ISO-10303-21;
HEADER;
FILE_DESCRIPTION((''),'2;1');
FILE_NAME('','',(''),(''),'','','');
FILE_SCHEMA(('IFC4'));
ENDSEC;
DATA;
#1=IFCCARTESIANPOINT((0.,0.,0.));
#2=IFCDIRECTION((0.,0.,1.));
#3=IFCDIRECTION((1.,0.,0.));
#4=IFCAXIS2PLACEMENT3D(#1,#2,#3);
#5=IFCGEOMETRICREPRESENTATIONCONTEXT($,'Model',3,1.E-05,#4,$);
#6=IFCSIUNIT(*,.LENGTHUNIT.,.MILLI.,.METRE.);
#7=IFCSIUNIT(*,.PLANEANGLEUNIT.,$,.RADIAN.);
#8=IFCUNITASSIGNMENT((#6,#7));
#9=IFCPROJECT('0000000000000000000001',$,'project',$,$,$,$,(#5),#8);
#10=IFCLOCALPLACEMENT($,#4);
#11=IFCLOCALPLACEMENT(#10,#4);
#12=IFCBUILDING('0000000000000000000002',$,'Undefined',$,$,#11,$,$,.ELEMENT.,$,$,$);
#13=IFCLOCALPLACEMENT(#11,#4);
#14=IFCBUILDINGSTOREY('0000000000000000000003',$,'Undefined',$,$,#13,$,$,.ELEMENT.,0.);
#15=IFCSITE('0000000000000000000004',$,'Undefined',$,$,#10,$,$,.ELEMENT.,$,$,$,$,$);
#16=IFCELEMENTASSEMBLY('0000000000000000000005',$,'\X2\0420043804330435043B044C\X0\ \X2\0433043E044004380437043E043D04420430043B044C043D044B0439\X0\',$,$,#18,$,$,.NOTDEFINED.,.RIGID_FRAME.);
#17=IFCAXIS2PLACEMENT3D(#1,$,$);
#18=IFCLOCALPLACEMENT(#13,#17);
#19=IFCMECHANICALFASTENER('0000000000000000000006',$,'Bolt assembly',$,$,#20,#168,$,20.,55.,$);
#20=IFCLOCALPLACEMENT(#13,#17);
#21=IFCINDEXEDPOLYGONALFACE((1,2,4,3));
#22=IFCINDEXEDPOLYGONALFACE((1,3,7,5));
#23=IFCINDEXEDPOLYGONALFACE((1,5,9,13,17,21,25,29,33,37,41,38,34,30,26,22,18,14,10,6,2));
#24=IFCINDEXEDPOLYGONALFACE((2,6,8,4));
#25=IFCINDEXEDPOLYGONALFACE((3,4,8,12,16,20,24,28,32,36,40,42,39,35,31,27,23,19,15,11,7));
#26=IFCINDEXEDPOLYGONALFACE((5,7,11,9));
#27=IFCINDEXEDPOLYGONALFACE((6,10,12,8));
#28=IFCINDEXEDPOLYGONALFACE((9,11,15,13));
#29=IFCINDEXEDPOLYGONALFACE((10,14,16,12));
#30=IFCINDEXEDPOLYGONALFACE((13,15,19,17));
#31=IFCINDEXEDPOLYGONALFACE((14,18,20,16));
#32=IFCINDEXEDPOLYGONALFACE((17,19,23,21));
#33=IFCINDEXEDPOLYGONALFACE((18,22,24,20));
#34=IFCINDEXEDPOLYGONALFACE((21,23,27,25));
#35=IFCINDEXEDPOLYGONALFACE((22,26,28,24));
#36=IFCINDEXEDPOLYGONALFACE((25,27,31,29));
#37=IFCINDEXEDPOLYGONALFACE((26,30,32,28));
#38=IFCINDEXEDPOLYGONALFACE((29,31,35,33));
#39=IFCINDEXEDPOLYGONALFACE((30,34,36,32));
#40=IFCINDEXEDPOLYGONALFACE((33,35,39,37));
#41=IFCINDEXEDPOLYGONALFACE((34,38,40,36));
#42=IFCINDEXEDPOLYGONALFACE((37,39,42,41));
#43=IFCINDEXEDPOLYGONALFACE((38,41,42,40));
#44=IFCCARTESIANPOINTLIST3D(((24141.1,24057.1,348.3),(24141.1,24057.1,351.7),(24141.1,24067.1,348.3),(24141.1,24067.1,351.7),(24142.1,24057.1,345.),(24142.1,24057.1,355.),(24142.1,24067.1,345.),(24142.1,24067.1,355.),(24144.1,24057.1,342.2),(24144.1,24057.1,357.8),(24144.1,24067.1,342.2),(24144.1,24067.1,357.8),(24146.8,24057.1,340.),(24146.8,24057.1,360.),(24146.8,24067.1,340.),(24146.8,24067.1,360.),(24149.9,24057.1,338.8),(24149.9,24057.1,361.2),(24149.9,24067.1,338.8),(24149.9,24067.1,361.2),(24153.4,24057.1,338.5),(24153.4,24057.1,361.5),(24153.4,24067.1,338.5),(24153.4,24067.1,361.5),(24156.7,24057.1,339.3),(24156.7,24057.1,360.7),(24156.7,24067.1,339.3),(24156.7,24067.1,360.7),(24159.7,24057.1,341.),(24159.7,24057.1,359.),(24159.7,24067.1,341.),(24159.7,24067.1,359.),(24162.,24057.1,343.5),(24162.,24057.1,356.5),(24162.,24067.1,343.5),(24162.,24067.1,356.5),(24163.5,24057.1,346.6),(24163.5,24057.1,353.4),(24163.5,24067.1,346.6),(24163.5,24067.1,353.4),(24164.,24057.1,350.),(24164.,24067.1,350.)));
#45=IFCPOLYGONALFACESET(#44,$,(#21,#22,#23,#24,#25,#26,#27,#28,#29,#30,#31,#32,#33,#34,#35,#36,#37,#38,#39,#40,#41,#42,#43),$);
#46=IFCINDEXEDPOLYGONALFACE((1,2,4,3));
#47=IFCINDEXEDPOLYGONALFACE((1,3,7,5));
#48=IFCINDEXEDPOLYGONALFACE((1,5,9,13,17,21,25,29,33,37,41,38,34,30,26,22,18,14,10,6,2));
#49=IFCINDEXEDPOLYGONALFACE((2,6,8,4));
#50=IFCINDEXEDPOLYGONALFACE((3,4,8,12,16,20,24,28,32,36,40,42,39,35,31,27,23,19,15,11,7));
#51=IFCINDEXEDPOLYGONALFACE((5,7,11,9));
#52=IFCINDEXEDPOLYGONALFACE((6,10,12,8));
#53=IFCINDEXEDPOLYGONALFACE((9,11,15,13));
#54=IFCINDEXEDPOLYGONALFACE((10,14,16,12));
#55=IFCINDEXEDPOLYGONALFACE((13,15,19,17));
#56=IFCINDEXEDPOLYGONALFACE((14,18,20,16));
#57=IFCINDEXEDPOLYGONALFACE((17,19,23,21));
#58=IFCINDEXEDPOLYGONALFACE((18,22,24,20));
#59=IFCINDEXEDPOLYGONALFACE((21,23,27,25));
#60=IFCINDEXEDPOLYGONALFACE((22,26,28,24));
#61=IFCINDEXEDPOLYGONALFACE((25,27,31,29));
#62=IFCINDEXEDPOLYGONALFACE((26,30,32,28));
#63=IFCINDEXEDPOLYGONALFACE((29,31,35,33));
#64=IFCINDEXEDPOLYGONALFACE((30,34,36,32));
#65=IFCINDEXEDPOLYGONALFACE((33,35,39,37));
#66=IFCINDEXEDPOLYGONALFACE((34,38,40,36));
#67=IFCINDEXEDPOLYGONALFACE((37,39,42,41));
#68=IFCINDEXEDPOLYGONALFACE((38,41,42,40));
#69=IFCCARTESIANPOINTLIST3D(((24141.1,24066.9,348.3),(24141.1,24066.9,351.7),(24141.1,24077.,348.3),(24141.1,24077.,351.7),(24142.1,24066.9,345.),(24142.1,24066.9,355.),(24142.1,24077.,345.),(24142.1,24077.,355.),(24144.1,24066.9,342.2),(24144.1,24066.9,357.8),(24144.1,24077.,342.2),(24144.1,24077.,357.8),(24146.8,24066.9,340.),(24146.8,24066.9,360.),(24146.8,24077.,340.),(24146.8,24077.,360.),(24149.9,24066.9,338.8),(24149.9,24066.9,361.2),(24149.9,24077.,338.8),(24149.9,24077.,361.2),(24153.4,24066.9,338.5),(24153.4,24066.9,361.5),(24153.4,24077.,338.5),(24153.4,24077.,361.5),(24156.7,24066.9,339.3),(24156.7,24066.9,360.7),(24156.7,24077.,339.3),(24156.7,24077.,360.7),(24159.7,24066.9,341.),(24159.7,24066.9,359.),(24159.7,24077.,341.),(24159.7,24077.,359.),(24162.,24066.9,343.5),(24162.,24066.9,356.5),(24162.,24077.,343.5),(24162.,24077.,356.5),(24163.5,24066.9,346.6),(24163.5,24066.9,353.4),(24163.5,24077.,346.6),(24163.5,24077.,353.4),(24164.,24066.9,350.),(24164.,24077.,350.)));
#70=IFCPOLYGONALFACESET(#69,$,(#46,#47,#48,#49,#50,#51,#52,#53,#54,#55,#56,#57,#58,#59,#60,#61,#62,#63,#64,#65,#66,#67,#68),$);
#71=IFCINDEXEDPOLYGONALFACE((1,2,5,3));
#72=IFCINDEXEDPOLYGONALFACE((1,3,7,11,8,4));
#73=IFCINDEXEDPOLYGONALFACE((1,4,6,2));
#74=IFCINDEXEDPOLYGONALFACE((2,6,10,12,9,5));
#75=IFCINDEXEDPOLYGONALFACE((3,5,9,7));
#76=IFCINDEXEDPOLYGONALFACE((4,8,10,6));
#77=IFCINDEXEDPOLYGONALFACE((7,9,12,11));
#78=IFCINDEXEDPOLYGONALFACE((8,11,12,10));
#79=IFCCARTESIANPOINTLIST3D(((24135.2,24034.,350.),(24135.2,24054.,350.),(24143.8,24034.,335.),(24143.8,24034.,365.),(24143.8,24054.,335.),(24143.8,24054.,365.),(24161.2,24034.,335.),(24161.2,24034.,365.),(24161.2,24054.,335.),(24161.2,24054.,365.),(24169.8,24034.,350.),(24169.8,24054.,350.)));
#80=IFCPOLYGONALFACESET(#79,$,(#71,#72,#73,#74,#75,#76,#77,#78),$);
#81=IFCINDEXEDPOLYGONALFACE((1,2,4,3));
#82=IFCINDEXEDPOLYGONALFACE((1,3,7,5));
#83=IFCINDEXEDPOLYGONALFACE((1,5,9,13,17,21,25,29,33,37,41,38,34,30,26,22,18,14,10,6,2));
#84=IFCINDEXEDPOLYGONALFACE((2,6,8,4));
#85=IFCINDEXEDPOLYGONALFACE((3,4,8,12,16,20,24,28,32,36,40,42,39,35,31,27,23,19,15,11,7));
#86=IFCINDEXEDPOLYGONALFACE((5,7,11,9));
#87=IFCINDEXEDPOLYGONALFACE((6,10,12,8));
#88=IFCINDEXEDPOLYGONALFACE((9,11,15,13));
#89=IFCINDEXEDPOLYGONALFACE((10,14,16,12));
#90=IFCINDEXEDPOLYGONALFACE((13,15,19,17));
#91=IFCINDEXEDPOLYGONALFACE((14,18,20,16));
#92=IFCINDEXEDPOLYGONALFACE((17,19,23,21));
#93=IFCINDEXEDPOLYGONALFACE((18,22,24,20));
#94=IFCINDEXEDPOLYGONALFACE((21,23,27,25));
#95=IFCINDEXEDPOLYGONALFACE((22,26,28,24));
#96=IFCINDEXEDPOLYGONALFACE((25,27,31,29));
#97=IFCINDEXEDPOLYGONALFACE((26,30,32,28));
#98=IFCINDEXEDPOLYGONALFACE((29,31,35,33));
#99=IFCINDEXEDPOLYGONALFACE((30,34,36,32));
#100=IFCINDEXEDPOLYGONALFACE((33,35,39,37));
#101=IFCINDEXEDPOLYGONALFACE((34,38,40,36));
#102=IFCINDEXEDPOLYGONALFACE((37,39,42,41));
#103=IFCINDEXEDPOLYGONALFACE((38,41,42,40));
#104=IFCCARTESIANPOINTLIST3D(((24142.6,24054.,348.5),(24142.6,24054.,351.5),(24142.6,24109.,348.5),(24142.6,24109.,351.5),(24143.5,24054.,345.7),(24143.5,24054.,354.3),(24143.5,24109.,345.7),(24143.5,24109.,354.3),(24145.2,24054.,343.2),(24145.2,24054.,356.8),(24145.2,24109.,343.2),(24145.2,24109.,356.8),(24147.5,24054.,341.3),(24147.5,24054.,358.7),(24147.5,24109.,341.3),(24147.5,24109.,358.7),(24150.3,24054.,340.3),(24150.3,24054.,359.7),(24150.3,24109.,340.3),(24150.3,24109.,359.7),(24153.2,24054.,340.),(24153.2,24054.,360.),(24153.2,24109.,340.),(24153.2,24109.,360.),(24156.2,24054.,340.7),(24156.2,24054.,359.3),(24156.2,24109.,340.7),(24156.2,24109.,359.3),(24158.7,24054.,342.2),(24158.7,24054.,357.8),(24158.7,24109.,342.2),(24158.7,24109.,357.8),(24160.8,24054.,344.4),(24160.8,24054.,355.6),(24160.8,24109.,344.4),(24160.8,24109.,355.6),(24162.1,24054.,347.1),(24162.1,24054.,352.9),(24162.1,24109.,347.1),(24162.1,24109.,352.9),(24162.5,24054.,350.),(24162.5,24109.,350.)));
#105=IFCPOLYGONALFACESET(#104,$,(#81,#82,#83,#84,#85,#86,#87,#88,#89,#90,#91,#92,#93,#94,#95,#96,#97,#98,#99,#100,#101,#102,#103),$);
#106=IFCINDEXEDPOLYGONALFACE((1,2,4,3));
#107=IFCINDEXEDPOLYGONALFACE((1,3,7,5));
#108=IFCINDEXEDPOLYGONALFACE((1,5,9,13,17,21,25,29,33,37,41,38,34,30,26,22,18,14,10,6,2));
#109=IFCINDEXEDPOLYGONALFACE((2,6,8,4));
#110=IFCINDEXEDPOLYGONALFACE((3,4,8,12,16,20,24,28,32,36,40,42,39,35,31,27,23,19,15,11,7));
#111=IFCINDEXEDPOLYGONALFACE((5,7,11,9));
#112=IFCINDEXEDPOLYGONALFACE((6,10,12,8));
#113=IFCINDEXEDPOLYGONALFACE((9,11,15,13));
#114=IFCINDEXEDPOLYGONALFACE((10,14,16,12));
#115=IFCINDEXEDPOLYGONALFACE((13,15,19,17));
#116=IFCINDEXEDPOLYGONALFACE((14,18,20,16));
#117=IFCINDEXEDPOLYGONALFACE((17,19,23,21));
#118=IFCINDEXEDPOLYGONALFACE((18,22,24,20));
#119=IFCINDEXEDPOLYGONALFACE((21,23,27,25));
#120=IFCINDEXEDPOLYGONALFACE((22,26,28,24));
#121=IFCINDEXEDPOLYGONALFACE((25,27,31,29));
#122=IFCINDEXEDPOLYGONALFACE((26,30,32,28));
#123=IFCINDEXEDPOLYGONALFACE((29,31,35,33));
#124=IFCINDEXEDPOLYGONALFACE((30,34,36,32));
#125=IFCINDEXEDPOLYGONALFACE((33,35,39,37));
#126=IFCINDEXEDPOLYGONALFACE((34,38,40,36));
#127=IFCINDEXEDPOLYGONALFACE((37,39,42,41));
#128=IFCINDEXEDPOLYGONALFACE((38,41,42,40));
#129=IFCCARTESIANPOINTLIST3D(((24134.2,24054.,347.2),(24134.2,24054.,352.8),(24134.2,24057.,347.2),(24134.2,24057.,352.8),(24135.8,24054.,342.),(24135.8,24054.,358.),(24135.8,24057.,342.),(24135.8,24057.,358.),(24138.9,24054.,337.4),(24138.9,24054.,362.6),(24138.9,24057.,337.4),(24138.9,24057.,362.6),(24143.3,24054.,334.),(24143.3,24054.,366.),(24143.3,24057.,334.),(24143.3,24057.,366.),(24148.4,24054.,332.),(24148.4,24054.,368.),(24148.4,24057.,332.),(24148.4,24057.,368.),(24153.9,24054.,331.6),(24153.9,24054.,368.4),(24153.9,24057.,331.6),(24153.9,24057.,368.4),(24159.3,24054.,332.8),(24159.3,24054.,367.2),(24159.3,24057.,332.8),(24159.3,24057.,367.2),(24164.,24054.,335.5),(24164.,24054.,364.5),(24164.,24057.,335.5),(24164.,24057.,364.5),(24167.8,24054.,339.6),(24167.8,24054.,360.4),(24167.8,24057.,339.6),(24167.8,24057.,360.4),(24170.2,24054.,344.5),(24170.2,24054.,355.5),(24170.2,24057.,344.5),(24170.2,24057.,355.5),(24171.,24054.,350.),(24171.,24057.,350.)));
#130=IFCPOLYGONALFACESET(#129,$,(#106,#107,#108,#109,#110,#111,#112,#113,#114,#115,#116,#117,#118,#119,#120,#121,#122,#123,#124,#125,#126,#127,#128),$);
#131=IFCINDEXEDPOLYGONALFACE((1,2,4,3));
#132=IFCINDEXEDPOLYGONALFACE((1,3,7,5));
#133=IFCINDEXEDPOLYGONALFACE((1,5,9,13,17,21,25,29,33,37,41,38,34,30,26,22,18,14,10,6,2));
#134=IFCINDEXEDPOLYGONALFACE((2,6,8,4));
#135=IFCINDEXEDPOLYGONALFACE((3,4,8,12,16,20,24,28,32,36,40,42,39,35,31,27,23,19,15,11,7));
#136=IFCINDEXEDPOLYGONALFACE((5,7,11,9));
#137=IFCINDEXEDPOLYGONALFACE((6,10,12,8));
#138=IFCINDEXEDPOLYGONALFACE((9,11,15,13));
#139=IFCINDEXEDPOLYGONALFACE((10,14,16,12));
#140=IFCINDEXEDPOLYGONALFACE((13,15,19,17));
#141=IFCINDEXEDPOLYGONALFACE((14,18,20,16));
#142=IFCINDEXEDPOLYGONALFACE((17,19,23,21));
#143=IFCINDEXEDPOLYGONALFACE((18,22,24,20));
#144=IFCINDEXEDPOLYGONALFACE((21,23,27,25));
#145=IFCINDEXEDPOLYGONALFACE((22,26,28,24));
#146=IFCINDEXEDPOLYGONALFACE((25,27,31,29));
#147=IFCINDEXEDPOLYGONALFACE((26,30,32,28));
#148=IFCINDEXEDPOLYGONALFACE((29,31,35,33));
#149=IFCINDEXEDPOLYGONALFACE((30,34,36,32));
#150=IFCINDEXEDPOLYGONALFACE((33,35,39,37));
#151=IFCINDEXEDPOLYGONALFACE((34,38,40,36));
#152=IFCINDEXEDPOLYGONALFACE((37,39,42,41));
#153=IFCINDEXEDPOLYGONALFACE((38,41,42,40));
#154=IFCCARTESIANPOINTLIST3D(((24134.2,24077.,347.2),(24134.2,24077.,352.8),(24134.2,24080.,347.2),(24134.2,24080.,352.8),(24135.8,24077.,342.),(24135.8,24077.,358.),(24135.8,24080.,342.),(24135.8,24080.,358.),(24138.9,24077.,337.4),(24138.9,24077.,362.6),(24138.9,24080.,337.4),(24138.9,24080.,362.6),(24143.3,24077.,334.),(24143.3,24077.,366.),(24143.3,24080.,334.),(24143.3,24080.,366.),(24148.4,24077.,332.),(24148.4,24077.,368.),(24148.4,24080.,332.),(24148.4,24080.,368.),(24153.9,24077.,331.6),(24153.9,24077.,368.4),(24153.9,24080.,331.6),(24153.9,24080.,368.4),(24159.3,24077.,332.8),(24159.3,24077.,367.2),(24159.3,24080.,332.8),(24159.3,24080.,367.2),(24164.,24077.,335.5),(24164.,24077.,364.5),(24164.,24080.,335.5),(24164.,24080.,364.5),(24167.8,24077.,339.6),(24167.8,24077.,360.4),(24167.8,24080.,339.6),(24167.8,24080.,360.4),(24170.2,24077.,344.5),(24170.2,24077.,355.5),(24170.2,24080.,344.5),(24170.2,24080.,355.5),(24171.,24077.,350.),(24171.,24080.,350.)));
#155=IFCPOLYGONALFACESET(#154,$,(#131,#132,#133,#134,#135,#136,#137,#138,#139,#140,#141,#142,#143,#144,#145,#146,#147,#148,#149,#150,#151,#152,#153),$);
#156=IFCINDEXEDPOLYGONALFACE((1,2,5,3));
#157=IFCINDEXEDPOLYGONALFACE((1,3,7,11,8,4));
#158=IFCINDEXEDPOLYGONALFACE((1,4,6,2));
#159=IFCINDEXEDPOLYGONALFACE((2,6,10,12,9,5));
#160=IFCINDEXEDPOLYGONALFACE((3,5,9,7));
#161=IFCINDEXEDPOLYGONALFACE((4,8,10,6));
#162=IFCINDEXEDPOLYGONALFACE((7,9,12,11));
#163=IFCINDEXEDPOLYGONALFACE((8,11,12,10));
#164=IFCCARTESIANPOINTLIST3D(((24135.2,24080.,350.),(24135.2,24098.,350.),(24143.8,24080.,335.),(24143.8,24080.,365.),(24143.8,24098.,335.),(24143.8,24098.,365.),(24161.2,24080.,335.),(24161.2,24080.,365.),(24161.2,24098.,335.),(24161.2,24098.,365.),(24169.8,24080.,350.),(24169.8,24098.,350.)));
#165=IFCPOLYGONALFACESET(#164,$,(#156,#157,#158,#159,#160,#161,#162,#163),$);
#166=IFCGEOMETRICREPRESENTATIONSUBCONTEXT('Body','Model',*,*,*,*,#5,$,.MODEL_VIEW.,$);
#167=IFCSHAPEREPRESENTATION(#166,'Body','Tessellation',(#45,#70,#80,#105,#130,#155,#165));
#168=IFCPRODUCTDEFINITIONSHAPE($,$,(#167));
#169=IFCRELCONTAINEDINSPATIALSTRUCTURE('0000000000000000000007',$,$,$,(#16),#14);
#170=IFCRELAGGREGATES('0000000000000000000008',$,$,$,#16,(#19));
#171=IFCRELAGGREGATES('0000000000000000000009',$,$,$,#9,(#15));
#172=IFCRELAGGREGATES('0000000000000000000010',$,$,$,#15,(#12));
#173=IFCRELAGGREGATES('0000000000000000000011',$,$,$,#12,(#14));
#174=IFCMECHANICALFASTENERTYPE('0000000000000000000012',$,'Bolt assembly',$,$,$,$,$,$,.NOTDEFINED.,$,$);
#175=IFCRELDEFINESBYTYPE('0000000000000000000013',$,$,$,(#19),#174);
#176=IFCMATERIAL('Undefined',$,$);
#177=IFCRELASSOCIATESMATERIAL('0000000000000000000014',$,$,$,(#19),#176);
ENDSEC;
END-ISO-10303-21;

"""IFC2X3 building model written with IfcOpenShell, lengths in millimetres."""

from ifc_helpers import new_model, si_unit, frame, origin_with_axes, origin_2d_with_axis, place, context, subcontext, project, spatial, polyline, circle, outline, extrude, source, transform, mapped, material, type_object, element, aggregate, save


model = new_model("IFC2X3")

# Units and contexts
model_context = context("Model", 3, precision=1e-05, world=origin_with_axes())
body_context = subcontext(model_context, "Body", "Model", "MODEL_VIEW")
ifc_project = project(units=[si_unit("LENGTHUNIT", "METRE", prefix="MILLI"), si_unit("PLANEANGLEUNIT", "RADIAN")], contexts=[model_context])

# Site, building, storey
site_placement = place(None, origin_with_axes())
site = spatial("IfcSite", under=ifc_project, at=site_placement, Name="Undefined", CompositionType="ELEMENT")
building_placement = place(site_placement, origin_with_axes())
building = spatial("IfcBuilding", under=site, at=building_placement, Name="Undefined", CompositionType="ELEMENT")
storey_placement = place(building_placement, origin_with_axes())
storey = spatial("IfcBuildingStorey", under=building, at=storey_placement, Name="Undefined", CompositionType="ELEMENT", Elevation=0.0)

# Element assembly
assembly_1_placement = place(storey_placement, origin_with_axes())
assembly_1 = element("IfcElementAssembly", 1, at=assembly_1_placement, inside=storey, Name="Ригель горизонтальный", AssemblyPlace="NOTDEFINED", PredefinedType="RIGID_FRAME")

# Mechanical fastener
ifc_material_1 = material(Name="Undefined")
mechanical_fastener_type = type_object("IfcMechanicalFastenerType", Name="Bolt assembly")
shared_shape = source(origin_with_axes(), body_context, "Body", "SweptSolid", [
    extrude(circle(Radius=11.5, at=origin_2d_with_axis()), frame((0.0, 0.1, 0.0), z_axis=(0.0, 1.0, 0.0), x_axis=(1.0, 0.0, 0.0)), (0.0, 0.0, 1.0), 10.0),
    extrude(circle(Radius=11.5, at=origin_2d_with_axis()), frame((0.0, 9.9, 0.0), z_axis=(0.0, 1.0, 0.0), x_axis=(1.0, 0.0, 0.0)), (0.0, 0.0, 1.0), 10.1),
    extrude(outline(polyline([(17.3, 0.0), (8.7, 15.0), (-8.7, 15.0), (-17.3, 0.0), (-8.7, -15.0), (8.7, -15.0), (17.3, 0.0)])), frame((0.0, -23.0, 0.0), z_axis=(0.0, 1.0, 0.0), x_axis=(1.0, 0.0, 0.0)), (0.0, 0.0, 1.0), 20.0),
    extrude(circle(Radius=10.0, at=origin_2d_with_axis()), frame((0.0, -3.0, 0.0), z_axis=(0.0, 1.0, 0.0), x_axis=(1.0, 0.0, 0.0)), (0.0, 0.0, 1.0), 55.0),
    extrude(circle(Radius=18.5, at=origin_2d_with_axis()), frame((0.0, -3.0, 0.0), z_axis=(0.0, 1.0, 0.0), x_axis=(1.0, 0.0, 0.0)), (0.0, 0.0, 1.0), 3.0),
    extrude(circle(Radius=18.5, at=origin_2d_with_axis()), frame((0.0, 20.0, 0.0), z_axis=(0.0, 1.0, 0.0), x_axis=(1.0, 0.0, 0.0)), (0.0, 0.0, 1.0), 3.0),
    extrude(outline(polyline([(17.3, 0.0), (8.7, 15.0), (-8.7, 15.0), (-17.3, 0.0), (-8.7, -15.0), (8.7, -15.0), (17.3, 0.0)])), frame((0.0, 23.0, 0.0), z_axis=(0.0, 1.0, 0.0), x_axis=(1.0, 0.0, 0.0)), (0.0, 0.0, 1.0), 18.0),
])
mechanical_fastener_1_placement = place(assembly_1_placement, frame((24152.5, 24057.0, 350.0), z_axis=(0.0, 0.0, 1.0), x_axis=(1.0, 0.0, 0.0)))
mechanical_fastener_1 = element("IfcMechanicalFastener", 2, at=mechanical_fastener_1_placement, type_object=mechanical_fastener_type, material=ifc_material_1, Name="Bolt assembly", NominalDiameter=20.0, NominalLength=55.0, context=body_context, shape_type="MappedRepresentation", body=[
    mapped(shared_shape, transform((0.0, 0.0, 0.0))),
])
aggregate(assembly_1, [mechanical_fastener_1])

save(model, "model.ifc")
